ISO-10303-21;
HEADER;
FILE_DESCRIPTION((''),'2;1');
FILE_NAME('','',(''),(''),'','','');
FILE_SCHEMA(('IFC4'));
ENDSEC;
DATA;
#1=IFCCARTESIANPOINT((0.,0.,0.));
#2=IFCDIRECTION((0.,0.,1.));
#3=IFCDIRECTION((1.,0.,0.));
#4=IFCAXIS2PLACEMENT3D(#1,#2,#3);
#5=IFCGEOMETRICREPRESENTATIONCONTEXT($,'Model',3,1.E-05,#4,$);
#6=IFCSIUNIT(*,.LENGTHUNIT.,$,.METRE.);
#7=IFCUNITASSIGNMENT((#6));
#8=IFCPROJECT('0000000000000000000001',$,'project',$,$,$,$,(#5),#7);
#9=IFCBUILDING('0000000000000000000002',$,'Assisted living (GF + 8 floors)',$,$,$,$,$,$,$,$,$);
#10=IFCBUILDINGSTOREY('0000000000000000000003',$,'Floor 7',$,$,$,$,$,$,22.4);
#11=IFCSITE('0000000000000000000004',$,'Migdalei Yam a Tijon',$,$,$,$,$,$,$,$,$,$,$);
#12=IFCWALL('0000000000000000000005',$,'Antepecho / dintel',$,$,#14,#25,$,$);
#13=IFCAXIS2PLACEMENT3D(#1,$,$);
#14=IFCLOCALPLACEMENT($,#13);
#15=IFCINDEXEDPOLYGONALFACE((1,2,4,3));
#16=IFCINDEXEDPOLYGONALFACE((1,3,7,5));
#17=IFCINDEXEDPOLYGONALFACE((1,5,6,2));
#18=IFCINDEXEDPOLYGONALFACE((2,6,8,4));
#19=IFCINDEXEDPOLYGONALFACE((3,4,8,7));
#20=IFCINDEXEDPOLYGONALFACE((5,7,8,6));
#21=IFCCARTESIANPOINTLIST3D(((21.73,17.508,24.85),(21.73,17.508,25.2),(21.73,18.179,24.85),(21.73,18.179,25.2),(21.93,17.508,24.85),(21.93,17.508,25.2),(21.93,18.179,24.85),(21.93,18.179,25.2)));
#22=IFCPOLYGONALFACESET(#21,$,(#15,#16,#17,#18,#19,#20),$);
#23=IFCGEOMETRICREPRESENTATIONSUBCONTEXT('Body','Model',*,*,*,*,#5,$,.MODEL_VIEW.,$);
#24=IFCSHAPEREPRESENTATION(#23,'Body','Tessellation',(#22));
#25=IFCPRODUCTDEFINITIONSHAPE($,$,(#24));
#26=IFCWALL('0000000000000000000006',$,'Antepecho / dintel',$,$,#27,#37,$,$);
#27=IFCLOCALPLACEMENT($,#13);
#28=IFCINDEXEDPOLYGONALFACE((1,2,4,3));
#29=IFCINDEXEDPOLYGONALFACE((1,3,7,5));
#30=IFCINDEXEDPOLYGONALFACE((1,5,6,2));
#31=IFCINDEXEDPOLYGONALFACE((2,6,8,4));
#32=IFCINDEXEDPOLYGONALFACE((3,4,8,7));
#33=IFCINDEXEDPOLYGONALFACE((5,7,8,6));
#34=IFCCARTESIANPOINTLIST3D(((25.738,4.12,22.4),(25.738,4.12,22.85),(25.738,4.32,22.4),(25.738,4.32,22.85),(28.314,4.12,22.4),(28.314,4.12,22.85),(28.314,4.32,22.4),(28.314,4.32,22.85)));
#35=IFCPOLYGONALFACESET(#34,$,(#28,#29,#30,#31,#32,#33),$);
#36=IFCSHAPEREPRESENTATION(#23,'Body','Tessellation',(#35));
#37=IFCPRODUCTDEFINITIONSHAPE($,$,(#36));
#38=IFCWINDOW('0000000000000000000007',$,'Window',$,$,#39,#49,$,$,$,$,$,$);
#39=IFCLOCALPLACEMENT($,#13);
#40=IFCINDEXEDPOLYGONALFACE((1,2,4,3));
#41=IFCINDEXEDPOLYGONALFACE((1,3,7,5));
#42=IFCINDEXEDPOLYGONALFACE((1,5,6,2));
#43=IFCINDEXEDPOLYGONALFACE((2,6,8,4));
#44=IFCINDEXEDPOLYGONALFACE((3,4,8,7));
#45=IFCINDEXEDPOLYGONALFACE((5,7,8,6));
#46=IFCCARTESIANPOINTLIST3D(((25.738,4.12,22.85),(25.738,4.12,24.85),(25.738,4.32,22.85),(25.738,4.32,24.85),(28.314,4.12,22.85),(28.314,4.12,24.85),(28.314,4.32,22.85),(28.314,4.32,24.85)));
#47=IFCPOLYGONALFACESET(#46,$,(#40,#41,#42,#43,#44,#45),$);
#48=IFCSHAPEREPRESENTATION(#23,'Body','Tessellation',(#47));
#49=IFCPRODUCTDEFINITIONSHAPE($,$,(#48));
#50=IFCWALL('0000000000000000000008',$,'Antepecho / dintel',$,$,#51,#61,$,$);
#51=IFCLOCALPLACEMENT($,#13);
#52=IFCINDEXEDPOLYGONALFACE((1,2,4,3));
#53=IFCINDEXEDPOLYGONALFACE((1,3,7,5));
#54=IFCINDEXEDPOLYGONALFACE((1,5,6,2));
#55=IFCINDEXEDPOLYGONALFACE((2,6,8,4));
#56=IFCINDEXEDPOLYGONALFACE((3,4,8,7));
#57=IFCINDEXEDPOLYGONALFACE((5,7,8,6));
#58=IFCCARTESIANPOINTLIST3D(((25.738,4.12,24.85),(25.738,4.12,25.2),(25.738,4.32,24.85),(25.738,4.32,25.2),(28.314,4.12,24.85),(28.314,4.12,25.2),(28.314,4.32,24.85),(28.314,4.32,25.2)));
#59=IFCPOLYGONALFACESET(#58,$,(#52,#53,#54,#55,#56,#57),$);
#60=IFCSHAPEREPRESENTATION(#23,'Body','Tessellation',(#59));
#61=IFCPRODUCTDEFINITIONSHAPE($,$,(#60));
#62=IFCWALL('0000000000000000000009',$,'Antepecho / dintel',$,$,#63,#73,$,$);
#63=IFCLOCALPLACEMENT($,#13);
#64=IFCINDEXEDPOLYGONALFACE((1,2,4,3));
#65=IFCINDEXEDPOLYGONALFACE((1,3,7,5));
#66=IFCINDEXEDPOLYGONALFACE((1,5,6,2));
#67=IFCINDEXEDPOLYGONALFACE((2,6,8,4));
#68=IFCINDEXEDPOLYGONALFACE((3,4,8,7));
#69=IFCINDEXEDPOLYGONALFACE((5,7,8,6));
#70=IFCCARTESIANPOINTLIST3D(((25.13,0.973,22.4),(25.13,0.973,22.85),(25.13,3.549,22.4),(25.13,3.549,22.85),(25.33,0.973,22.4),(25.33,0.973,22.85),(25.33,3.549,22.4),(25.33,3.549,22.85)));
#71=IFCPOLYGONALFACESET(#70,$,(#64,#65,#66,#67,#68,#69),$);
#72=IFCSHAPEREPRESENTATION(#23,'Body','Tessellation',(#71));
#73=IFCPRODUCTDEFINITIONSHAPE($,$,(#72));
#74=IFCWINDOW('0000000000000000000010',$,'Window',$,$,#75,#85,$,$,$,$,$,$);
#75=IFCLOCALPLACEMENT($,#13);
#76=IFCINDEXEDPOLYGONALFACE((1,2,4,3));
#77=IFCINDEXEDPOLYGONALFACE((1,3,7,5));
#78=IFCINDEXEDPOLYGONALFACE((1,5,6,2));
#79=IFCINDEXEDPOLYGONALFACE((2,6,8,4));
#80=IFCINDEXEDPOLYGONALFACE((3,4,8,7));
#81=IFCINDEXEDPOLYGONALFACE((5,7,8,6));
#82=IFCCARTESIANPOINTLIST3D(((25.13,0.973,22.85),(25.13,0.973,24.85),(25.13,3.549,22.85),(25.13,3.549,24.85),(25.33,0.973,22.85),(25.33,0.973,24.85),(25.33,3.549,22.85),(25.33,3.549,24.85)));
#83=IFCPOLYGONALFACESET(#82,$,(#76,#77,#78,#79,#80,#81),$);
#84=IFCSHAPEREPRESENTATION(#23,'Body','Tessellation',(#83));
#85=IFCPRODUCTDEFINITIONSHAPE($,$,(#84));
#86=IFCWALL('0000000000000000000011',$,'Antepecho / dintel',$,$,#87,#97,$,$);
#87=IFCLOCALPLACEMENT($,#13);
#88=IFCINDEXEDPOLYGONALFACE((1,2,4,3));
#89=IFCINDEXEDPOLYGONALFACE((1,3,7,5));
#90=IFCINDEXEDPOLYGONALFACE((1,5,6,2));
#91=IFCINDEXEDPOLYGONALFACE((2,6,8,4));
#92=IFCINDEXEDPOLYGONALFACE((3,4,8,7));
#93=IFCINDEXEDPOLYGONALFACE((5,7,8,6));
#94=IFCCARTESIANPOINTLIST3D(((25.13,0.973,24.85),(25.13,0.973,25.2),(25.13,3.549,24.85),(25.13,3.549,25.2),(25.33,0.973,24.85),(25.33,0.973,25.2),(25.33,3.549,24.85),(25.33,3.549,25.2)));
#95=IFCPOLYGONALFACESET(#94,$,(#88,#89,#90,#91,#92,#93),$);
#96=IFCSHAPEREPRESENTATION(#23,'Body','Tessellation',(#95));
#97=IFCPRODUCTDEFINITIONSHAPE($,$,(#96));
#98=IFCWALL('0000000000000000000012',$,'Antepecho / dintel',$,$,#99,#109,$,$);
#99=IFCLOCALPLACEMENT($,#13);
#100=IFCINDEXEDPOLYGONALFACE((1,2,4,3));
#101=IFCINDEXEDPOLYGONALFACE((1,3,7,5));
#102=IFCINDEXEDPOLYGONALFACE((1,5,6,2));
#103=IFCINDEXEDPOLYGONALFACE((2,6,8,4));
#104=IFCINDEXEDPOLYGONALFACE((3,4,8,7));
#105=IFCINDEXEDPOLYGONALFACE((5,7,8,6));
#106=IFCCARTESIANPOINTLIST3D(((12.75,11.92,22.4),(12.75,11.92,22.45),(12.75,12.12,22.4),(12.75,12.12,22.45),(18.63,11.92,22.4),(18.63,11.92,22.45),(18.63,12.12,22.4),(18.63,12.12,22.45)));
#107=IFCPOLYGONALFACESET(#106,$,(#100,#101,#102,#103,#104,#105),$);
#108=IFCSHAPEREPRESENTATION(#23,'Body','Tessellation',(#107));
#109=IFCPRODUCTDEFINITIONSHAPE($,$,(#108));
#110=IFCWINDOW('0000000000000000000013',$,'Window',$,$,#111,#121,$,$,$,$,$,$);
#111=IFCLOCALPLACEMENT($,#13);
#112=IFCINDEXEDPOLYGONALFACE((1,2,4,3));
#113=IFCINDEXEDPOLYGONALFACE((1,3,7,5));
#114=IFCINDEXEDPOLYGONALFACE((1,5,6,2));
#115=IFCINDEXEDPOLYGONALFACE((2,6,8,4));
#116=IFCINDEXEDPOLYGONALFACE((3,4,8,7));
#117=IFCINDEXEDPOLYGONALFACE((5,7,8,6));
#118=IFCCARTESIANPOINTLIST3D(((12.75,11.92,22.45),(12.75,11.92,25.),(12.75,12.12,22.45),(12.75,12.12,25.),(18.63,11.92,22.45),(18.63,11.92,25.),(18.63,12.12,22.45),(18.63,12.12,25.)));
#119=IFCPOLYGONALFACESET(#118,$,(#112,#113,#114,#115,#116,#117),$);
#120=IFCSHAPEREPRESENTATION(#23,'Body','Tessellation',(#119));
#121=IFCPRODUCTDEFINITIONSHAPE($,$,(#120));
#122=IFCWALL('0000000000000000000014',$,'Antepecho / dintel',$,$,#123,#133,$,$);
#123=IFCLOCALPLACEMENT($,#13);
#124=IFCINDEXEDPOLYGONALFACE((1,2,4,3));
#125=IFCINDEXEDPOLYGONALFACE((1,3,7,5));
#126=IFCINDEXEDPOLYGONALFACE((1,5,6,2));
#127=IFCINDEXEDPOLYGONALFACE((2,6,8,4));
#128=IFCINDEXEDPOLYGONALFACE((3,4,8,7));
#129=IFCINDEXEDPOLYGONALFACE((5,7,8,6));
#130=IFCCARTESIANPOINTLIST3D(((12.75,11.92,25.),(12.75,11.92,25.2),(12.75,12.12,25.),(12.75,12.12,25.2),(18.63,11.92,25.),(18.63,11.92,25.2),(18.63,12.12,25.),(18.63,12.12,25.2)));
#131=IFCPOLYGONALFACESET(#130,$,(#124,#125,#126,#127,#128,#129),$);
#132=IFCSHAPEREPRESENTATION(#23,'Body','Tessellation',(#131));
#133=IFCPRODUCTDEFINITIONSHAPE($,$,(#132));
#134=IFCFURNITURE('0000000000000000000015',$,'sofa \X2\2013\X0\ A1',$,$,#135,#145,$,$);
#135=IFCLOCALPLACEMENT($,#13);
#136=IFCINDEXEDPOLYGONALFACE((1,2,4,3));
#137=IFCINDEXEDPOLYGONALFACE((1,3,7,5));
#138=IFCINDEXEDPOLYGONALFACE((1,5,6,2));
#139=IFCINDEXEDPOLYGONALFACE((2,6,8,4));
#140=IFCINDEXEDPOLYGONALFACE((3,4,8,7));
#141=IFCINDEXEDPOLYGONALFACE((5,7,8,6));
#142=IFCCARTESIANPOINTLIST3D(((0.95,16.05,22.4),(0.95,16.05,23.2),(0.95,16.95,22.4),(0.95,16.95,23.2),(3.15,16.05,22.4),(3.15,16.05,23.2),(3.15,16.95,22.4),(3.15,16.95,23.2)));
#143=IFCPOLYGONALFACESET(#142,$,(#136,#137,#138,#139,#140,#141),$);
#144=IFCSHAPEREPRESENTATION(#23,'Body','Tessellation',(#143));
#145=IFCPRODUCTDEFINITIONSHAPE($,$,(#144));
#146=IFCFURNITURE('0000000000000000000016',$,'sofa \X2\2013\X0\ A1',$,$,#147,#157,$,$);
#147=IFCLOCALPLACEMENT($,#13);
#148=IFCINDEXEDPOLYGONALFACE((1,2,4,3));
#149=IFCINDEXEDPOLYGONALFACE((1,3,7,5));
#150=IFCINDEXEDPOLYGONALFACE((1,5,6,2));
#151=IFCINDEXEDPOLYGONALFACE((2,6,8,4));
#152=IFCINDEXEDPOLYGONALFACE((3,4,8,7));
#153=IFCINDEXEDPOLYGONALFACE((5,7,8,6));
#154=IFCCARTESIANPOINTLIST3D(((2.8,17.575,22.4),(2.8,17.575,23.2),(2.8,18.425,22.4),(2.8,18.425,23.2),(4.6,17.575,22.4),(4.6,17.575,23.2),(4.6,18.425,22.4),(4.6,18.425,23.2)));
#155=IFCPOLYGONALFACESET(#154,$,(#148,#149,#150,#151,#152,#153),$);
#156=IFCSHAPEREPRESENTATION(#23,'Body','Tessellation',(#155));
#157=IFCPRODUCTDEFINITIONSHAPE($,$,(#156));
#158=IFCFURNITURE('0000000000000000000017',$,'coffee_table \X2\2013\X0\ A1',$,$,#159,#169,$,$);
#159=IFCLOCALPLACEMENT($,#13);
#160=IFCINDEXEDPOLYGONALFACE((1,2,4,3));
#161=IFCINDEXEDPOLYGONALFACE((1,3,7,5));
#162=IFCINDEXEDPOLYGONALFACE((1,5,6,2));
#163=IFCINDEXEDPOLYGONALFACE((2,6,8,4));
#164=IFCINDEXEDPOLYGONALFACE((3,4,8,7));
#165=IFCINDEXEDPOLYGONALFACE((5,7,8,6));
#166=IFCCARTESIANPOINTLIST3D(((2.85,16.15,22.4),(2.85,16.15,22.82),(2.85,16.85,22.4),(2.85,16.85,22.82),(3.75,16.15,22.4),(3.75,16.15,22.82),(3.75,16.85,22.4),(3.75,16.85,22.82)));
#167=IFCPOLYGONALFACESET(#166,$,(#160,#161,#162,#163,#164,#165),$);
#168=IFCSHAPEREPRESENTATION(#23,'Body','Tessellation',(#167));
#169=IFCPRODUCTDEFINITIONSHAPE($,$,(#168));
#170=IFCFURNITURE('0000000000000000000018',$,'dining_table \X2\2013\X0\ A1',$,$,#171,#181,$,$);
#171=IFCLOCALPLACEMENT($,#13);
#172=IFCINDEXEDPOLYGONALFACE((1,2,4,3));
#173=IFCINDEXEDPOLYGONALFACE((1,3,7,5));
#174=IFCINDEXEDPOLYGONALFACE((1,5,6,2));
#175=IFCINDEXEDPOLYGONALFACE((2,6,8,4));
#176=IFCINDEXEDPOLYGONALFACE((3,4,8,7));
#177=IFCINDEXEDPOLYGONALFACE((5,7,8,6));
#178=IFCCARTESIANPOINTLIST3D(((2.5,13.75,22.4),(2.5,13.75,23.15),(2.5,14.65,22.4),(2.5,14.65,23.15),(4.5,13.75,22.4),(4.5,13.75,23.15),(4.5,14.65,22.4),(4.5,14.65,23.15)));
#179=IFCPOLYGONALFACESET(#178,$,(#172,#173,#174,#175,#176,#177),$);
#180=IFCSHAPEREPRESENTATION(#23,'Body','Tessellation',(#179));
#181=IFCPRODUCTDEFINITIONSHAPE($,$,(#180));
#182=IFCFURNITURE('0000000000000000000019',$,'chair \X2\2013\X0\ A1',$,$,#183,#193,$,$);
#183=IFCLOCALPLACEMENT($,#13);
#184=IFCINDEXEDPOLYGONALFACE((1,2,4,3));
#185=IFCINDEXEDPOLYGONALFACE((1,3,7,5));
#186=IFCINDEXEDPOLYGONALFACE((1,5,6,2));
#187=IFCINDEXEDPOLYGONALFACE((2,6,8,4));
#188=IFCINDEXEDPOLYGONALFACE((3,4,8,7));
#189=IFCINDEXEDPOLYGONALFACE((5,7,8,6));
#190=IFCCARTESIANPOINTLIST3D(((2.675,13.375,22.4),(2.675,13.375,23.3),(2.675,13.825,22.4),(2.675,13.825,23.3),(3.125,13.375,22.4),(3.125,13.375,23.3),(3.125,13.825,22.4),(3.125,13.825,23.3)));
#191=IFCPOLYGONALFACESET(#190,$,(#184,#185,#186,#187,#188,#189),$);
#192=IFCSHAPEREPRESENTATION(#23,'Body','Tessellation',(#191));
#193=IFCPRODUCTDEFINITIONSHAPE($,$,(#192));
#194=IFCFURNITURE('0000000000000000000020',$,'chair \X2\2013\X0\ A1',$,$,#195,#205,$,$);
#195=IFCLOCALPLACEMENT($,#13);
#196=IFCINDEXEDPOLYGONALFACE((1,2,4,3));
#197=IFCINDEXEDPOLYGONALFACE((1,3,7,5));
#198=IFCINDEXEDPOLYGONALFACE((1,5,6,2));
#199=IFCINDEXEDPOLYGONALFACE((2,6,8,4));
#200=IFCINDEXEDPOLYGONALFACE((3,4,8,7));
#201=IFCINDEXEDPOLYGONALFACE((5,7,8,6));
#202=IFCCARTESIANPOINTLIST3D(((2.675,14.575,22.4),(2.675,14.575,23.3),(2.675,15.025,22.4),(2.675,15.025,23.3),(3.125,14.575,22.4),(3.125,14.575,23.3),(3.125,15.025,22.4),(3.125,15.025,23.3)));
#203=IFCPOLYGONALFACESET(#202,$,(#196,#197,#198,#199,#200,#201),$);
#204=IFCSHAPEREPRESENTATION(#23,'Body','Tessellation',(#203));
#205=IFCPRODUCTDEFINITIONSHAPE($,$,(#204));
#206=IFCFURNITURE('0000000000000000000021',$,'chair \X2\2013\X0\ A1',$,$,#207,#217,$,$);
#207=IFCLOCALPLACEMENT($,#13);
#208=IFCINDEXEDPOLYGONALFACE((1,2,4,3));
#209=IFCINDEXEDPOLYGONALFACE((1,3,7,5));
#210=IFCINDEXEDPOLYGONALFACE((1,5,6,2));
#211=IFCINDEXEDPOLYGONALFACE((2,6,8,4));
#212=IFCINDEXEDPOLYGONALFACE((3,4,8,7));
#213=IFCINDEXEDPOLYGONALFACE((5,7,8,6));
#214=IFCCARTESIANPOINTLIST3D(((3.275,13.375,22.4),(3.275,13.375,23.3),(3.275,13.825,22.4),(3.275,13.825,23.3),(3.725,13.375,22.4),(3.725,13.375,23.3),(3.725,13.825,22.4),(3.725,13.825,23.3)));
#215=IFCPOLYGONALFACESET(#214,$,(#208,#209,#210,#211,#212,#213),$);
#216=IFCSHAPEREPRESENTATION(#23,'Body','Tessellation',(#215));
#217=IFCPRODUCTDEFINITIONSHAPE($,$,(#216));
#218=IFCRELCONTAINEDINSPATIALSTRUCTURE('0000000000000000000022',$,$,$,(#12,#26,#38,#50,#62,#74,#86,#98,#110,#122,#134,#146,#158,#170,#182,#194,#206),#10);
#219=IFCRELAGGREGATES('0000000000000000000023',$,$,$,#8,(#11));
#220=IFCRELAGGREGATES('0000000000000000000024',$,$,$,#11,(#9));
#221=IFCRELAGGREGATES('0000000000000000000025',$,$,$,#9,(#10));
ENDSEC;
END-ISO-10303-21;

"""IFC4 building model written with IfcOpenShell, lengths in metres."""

from ifc_helpers import new_model, si_unit, frame, origin_with_axes, context, subcontext, project, spatial, line, indexed_curve, outline, extrude, element, save


model = new_model("IFC4")

# Units and contexts
model_context = context("Model", 3, precision=1e-05, world=origin_with_axes())
body_context = subcontext(model_context, "Body", "Model", "MODEL_VIEW")
ifc_project = project(units=[si_unit("LENGTHUNIT", "METRE")], contexts=[model_context])

# Site, building, storey
site = spatial("IfcSite", under=ifc_project, Name="Migdalei Yam a Tijon")
building = spatial("IfcBuilding", under=site, Name="Assisted living (GF + 8 floors)")
storey = spatial("IfcBuildingStorey", under=building, Name="Floor 7", Elevation=22.4)

# Walls
element("IfcWall", 1, inside=storey, Name="Antepecho / dintel", context=body_context, shape_type="SweptSolid", body=[
    extrude(outline(indexed_curve([(0.0, 0.0), (0.2, 0.0), (0.2, 0.671), (0.0, 0.671)], segments=[line(1, 2, 3, 4, 1)])), frame((21.73, 17.508, 24.85), z_axis=(0.0, 0.0, 1.0), x_axis=(1.0, 0.0, 0.0)), (0.0, 0.0, 1.0), 0.35),
])
element("IfcWall", 2, inside=storey, Name="Antepecho / dintel", context=body_context, shape_type="SweptSolid", body=[
    extrude(outline(indexed_curve([(0.0, 0.0), (2.576, 0.0), (2.576, 0.2), (0.0, 0.2)], segments=[line(1, 2, 3, 4, 1)])), frame((25.738, 4.12, 22.4), z_axis=(0.0, 0.0, 1.0), x_axis=(1.0, 0.0, 0.0)), (0.0, 0.0, 1.0), 0.45),
])

# Window
element("IfcWindow", 3, inside=storey, Name="Window", context=body_context, shape_type="SweptSolid", body=[
    extrude(outline(indexed_curve([(0.0, 0.0), (2.576, 0.0), (2.576, 0.2), (0.0, 0.2)], segments=[line(1, 2, 3, 4, 1)])), frame((25.738, 4.12, 22.85), z_axis=(0.0, 0.0, 1.0), x_axis=(1.0, 0.0, 0.0)), (0.0, 0.0, 1.0), 2.0),
])

# Walls
element("IfcWall", 4, inside=storey, Name="Antepecho / dintel", context=body_context, shape_type="SweptSolid", body=[
    extrude(outline(indexed_curve([(0.0, 0.0), (2.576, 0.0), (2.576, 0.2), (0.0, 0.2)], segments=[line(1, 2, 3, 4, 1)])), frame((25.738, 4.12, 24.85), z_axis=(0.0, 0.0, 1.0), x_axis=(1.0, 0.0, 0.0)), (0.0, 0.0, 1.0), 0.35),
])
element("IfcWall", 5, inside=storey, Name="Antepecho / dintel", context=body_context, shape_type="SweptSolid", body=[
    extrude(outline(indexed_curve([(0.0, 0.0), (0.2, 0.0), (0.2, 2.576), (0.0, 2.576)], segments=[line(1, 2, 3, 4, 1)])), frame((25.13, 0.973, 22.4), z_axis=(0.0, 0.0, 1.0), x_axis=(1.0, 0.0, 0.0)), (0.0, 0.0, 1.0), 0.45),
])

# Window
element("IfcWindow", 6, inside=storey, Name="Window", context=body_context, shape_type="SweptSolid", body=[
    extrude(outline(indexed_curve([(0.0, 0.0), (0.2, 0.0), (0.2, 2.576), (0.0, 2.576)], segments=[line(1, 2, 3, 4, 1)])), frame((25.13, 0.973, 22.85), z_axis=(0.0, 0.0, 1.0), x_axis=(1.0, 0.0, 0.0)), (0.0, 0.0, 1.0), 2.0),
])

# Walls
element("IfcWall", 7, inside=storey, Name="Antepecho / dintel", context=body_context, shape_type="SweptSolid", body=[
    extrude(outline(indexed_curve([(0.0, 0.0), (0.2, 0.0), (0.2, 2.576), (0.0, 2.576)], segments=[line(1, 2, 3, 4, 1)])), frame((25.13, 0.973, 24.85), z_axis=(0.0, 0.0, 1.0), x_axis=(1.0, 0.0, 0.0)), (0.0, 0.0, 1.0), 0.35),
])
element("IfcWall", 8, inside=storey, Name="Antepecho / dintel", context=body_context, shape_type="SweptSolid", body=[
    extrude(outline(indexed_curve([(0.0, 0.0), (5.88, 0.0), (5.88, 0.2), (0.0, 0.2)], segments=[line(1, 2, 3, 4, 1)])), frame((12.75, 11.92, 22.4), z_axis=(0.0, 0.0, 1.0), x_axis=(1.0, 0.0, 0.0)), (0.0, 0.0, 1.0), 0.05),
])

# Window
element("IfcWindow", 9, inside=storey, Name="Window", context=body_context, shape_type="SweptSolid", body=[
    extrude(outline(indexed_curve([(0.0, 0.0), (5.88, 0.0), (5.88, 0.2), (0.0, 0.2)], segments=[line(1, 2, 3, 4, 1)])), frame((12.75, 11.92, 22.45), z_axis=(0.0, 0.0, 1.0), x_axis=(1.0, 0.0, 0.0)), (0.0, 0.0, 1.0), 2.55),
])

# Wall
element("IfcWall", 10, inside=storey, Name="Antepecho / dintel", context=body_context, shape_type="SweptSolid", body=[
    extrude(outline(indexed_curve([(0.0, 0.0), (5.88, 0.0), (5.88, 0.2), (0.0, 0.2)], segments=[line(1, 2, 3, 4, 1)])), frame((12.75, 11.92, 25.0), z_axis=(0.0, 0.0, 1.0), x_axis=(1.0, 0.0, 0.0)), (0.0, 0.0, 1.0), 0.2),
])

# Furniture
element("IfcFurniture", 11, inside=storey, Name="sofa – A1", context=body_context, shape_type="SweptSolid", body=[
    extrude(outline(indexed_curve([(0.0, 0.0), (2.2, 0.0), (2.2, 0.9), (0.0, 0.9)], segments=[line(1, 2, 3, 4, 1)])), frame((0.95, 16.05, 22.4), z_axis=(0.0, 0.0, 1.0), x_axis=(1.0, 0.0, 0.0)), (0.0, 0.0, 1.0), 0.8),
])
element("IfcFurniture", 12, inside=storey, Name="sofa – A1", context=body_context, shape_type="SweptSolid", body=[
    extrude(outline(indexed_curve([(0.0, 0.0), (1.8, 0.0), (1.8, 0.85), (0.0, 0.85)], segments=[line(1, 2, 3, 4, 1)])), frame((2.8, 17.575, 22.4), z_axis=(0.0, 0.0, 1.0), x_axis=(1.0, 0.0, 0.0)), (0.0, 0.0, 1.0), 0.8),
])
element("IfcFurniture", 13, inside=storey, Name="coffee_table – A1", context=body_context, shape_type="SweptSolid", body=[
    extrude(outline(indexed_curve([(0.0, 0.0), (0.9, 0.0), (0.9, 0.7), (0.0, 0.7)], segments=[line(1, 2, 3, 4, 1)])), frame((2.85, 16.15, 22.4), z_axis=(0.0, 0.0, 1.0), x_axis=(1.0, 0.0, 0.0)), (0.0, 0.0, 1.0), 0.42),
])
element("IfcFurniture", 14, inside=storey, Name="dining_table – A1", context=body_context, shape_type="SweptSolid", body=[
    extrude(outline(indexed_curve([(0.0, 0.0), (2.0, 0.0), (2.0, 0.9), (0.0, 0.9)], segments=[line(1, 2, 3, 4, 1)])), frame((2.5, 13.75, 22.4), z_axis=(0.0, 0.0, 1.0), x_axis=(1.0, 0.0, 0.0)), (0.0, 0.0, 1.0), 0.75),
])
element("IfcFurniture", 15, inside=storey, Name="chair – A1", context=body_context, shape_type="SweptSolid", body=[
    extrude(outline(indexed_curve([(0.0, 0.0), (0.45, 0.0), (0.45, 0.45), (0.0, 0.45)], segments=[line(1, 2, 3, 4, 1)])), frame((2.675, 13.375, 22.4), z_axis=(0.0, 0.0, 1.0), x_axis=(1.0, 0.0, 0.0)), (0.0, 0.0, 1.0), 0.9),
])
element("IfcFurniture", 16, inside=storey, Name="chair – A1", context=body_context, shape_type="SweptSolid", body=[
    extrude(outline(indexed_curve([(0.0, 0.0), (0.45, 0.0), (0.45, 0.45), (0.0, 0.45)], segments=[line(1, 2, 3, 4, 1)])), frame((2.675, 14.575, 22.4), z_axis=(0.0, 0.0, 1.0), x_axis=(1.0, 0.0, 0.0)), (0.0, 0.0, 1.0), 0.9),
])
element("IfcFurniture", 17, inside=storey, Name="chair – A1", context=body_context, shape_type="SweptSolid", body=[
    extrude(outline(indexed_curve([(0.0, 0.0), (0.45, 0.0), (0.45, 0.45), (0.0, 0.45)], segments=[line(1, 2, 3, 4, 1)])), frame((3.275, 13.375, 22.4), z_axis=(0.0, 0.0, 1.0), x_axis=(1.0, 0.0, 0.0)), (0.0, 0.0, 1.0), 0.9),
])

save(model, "model.ifc")
